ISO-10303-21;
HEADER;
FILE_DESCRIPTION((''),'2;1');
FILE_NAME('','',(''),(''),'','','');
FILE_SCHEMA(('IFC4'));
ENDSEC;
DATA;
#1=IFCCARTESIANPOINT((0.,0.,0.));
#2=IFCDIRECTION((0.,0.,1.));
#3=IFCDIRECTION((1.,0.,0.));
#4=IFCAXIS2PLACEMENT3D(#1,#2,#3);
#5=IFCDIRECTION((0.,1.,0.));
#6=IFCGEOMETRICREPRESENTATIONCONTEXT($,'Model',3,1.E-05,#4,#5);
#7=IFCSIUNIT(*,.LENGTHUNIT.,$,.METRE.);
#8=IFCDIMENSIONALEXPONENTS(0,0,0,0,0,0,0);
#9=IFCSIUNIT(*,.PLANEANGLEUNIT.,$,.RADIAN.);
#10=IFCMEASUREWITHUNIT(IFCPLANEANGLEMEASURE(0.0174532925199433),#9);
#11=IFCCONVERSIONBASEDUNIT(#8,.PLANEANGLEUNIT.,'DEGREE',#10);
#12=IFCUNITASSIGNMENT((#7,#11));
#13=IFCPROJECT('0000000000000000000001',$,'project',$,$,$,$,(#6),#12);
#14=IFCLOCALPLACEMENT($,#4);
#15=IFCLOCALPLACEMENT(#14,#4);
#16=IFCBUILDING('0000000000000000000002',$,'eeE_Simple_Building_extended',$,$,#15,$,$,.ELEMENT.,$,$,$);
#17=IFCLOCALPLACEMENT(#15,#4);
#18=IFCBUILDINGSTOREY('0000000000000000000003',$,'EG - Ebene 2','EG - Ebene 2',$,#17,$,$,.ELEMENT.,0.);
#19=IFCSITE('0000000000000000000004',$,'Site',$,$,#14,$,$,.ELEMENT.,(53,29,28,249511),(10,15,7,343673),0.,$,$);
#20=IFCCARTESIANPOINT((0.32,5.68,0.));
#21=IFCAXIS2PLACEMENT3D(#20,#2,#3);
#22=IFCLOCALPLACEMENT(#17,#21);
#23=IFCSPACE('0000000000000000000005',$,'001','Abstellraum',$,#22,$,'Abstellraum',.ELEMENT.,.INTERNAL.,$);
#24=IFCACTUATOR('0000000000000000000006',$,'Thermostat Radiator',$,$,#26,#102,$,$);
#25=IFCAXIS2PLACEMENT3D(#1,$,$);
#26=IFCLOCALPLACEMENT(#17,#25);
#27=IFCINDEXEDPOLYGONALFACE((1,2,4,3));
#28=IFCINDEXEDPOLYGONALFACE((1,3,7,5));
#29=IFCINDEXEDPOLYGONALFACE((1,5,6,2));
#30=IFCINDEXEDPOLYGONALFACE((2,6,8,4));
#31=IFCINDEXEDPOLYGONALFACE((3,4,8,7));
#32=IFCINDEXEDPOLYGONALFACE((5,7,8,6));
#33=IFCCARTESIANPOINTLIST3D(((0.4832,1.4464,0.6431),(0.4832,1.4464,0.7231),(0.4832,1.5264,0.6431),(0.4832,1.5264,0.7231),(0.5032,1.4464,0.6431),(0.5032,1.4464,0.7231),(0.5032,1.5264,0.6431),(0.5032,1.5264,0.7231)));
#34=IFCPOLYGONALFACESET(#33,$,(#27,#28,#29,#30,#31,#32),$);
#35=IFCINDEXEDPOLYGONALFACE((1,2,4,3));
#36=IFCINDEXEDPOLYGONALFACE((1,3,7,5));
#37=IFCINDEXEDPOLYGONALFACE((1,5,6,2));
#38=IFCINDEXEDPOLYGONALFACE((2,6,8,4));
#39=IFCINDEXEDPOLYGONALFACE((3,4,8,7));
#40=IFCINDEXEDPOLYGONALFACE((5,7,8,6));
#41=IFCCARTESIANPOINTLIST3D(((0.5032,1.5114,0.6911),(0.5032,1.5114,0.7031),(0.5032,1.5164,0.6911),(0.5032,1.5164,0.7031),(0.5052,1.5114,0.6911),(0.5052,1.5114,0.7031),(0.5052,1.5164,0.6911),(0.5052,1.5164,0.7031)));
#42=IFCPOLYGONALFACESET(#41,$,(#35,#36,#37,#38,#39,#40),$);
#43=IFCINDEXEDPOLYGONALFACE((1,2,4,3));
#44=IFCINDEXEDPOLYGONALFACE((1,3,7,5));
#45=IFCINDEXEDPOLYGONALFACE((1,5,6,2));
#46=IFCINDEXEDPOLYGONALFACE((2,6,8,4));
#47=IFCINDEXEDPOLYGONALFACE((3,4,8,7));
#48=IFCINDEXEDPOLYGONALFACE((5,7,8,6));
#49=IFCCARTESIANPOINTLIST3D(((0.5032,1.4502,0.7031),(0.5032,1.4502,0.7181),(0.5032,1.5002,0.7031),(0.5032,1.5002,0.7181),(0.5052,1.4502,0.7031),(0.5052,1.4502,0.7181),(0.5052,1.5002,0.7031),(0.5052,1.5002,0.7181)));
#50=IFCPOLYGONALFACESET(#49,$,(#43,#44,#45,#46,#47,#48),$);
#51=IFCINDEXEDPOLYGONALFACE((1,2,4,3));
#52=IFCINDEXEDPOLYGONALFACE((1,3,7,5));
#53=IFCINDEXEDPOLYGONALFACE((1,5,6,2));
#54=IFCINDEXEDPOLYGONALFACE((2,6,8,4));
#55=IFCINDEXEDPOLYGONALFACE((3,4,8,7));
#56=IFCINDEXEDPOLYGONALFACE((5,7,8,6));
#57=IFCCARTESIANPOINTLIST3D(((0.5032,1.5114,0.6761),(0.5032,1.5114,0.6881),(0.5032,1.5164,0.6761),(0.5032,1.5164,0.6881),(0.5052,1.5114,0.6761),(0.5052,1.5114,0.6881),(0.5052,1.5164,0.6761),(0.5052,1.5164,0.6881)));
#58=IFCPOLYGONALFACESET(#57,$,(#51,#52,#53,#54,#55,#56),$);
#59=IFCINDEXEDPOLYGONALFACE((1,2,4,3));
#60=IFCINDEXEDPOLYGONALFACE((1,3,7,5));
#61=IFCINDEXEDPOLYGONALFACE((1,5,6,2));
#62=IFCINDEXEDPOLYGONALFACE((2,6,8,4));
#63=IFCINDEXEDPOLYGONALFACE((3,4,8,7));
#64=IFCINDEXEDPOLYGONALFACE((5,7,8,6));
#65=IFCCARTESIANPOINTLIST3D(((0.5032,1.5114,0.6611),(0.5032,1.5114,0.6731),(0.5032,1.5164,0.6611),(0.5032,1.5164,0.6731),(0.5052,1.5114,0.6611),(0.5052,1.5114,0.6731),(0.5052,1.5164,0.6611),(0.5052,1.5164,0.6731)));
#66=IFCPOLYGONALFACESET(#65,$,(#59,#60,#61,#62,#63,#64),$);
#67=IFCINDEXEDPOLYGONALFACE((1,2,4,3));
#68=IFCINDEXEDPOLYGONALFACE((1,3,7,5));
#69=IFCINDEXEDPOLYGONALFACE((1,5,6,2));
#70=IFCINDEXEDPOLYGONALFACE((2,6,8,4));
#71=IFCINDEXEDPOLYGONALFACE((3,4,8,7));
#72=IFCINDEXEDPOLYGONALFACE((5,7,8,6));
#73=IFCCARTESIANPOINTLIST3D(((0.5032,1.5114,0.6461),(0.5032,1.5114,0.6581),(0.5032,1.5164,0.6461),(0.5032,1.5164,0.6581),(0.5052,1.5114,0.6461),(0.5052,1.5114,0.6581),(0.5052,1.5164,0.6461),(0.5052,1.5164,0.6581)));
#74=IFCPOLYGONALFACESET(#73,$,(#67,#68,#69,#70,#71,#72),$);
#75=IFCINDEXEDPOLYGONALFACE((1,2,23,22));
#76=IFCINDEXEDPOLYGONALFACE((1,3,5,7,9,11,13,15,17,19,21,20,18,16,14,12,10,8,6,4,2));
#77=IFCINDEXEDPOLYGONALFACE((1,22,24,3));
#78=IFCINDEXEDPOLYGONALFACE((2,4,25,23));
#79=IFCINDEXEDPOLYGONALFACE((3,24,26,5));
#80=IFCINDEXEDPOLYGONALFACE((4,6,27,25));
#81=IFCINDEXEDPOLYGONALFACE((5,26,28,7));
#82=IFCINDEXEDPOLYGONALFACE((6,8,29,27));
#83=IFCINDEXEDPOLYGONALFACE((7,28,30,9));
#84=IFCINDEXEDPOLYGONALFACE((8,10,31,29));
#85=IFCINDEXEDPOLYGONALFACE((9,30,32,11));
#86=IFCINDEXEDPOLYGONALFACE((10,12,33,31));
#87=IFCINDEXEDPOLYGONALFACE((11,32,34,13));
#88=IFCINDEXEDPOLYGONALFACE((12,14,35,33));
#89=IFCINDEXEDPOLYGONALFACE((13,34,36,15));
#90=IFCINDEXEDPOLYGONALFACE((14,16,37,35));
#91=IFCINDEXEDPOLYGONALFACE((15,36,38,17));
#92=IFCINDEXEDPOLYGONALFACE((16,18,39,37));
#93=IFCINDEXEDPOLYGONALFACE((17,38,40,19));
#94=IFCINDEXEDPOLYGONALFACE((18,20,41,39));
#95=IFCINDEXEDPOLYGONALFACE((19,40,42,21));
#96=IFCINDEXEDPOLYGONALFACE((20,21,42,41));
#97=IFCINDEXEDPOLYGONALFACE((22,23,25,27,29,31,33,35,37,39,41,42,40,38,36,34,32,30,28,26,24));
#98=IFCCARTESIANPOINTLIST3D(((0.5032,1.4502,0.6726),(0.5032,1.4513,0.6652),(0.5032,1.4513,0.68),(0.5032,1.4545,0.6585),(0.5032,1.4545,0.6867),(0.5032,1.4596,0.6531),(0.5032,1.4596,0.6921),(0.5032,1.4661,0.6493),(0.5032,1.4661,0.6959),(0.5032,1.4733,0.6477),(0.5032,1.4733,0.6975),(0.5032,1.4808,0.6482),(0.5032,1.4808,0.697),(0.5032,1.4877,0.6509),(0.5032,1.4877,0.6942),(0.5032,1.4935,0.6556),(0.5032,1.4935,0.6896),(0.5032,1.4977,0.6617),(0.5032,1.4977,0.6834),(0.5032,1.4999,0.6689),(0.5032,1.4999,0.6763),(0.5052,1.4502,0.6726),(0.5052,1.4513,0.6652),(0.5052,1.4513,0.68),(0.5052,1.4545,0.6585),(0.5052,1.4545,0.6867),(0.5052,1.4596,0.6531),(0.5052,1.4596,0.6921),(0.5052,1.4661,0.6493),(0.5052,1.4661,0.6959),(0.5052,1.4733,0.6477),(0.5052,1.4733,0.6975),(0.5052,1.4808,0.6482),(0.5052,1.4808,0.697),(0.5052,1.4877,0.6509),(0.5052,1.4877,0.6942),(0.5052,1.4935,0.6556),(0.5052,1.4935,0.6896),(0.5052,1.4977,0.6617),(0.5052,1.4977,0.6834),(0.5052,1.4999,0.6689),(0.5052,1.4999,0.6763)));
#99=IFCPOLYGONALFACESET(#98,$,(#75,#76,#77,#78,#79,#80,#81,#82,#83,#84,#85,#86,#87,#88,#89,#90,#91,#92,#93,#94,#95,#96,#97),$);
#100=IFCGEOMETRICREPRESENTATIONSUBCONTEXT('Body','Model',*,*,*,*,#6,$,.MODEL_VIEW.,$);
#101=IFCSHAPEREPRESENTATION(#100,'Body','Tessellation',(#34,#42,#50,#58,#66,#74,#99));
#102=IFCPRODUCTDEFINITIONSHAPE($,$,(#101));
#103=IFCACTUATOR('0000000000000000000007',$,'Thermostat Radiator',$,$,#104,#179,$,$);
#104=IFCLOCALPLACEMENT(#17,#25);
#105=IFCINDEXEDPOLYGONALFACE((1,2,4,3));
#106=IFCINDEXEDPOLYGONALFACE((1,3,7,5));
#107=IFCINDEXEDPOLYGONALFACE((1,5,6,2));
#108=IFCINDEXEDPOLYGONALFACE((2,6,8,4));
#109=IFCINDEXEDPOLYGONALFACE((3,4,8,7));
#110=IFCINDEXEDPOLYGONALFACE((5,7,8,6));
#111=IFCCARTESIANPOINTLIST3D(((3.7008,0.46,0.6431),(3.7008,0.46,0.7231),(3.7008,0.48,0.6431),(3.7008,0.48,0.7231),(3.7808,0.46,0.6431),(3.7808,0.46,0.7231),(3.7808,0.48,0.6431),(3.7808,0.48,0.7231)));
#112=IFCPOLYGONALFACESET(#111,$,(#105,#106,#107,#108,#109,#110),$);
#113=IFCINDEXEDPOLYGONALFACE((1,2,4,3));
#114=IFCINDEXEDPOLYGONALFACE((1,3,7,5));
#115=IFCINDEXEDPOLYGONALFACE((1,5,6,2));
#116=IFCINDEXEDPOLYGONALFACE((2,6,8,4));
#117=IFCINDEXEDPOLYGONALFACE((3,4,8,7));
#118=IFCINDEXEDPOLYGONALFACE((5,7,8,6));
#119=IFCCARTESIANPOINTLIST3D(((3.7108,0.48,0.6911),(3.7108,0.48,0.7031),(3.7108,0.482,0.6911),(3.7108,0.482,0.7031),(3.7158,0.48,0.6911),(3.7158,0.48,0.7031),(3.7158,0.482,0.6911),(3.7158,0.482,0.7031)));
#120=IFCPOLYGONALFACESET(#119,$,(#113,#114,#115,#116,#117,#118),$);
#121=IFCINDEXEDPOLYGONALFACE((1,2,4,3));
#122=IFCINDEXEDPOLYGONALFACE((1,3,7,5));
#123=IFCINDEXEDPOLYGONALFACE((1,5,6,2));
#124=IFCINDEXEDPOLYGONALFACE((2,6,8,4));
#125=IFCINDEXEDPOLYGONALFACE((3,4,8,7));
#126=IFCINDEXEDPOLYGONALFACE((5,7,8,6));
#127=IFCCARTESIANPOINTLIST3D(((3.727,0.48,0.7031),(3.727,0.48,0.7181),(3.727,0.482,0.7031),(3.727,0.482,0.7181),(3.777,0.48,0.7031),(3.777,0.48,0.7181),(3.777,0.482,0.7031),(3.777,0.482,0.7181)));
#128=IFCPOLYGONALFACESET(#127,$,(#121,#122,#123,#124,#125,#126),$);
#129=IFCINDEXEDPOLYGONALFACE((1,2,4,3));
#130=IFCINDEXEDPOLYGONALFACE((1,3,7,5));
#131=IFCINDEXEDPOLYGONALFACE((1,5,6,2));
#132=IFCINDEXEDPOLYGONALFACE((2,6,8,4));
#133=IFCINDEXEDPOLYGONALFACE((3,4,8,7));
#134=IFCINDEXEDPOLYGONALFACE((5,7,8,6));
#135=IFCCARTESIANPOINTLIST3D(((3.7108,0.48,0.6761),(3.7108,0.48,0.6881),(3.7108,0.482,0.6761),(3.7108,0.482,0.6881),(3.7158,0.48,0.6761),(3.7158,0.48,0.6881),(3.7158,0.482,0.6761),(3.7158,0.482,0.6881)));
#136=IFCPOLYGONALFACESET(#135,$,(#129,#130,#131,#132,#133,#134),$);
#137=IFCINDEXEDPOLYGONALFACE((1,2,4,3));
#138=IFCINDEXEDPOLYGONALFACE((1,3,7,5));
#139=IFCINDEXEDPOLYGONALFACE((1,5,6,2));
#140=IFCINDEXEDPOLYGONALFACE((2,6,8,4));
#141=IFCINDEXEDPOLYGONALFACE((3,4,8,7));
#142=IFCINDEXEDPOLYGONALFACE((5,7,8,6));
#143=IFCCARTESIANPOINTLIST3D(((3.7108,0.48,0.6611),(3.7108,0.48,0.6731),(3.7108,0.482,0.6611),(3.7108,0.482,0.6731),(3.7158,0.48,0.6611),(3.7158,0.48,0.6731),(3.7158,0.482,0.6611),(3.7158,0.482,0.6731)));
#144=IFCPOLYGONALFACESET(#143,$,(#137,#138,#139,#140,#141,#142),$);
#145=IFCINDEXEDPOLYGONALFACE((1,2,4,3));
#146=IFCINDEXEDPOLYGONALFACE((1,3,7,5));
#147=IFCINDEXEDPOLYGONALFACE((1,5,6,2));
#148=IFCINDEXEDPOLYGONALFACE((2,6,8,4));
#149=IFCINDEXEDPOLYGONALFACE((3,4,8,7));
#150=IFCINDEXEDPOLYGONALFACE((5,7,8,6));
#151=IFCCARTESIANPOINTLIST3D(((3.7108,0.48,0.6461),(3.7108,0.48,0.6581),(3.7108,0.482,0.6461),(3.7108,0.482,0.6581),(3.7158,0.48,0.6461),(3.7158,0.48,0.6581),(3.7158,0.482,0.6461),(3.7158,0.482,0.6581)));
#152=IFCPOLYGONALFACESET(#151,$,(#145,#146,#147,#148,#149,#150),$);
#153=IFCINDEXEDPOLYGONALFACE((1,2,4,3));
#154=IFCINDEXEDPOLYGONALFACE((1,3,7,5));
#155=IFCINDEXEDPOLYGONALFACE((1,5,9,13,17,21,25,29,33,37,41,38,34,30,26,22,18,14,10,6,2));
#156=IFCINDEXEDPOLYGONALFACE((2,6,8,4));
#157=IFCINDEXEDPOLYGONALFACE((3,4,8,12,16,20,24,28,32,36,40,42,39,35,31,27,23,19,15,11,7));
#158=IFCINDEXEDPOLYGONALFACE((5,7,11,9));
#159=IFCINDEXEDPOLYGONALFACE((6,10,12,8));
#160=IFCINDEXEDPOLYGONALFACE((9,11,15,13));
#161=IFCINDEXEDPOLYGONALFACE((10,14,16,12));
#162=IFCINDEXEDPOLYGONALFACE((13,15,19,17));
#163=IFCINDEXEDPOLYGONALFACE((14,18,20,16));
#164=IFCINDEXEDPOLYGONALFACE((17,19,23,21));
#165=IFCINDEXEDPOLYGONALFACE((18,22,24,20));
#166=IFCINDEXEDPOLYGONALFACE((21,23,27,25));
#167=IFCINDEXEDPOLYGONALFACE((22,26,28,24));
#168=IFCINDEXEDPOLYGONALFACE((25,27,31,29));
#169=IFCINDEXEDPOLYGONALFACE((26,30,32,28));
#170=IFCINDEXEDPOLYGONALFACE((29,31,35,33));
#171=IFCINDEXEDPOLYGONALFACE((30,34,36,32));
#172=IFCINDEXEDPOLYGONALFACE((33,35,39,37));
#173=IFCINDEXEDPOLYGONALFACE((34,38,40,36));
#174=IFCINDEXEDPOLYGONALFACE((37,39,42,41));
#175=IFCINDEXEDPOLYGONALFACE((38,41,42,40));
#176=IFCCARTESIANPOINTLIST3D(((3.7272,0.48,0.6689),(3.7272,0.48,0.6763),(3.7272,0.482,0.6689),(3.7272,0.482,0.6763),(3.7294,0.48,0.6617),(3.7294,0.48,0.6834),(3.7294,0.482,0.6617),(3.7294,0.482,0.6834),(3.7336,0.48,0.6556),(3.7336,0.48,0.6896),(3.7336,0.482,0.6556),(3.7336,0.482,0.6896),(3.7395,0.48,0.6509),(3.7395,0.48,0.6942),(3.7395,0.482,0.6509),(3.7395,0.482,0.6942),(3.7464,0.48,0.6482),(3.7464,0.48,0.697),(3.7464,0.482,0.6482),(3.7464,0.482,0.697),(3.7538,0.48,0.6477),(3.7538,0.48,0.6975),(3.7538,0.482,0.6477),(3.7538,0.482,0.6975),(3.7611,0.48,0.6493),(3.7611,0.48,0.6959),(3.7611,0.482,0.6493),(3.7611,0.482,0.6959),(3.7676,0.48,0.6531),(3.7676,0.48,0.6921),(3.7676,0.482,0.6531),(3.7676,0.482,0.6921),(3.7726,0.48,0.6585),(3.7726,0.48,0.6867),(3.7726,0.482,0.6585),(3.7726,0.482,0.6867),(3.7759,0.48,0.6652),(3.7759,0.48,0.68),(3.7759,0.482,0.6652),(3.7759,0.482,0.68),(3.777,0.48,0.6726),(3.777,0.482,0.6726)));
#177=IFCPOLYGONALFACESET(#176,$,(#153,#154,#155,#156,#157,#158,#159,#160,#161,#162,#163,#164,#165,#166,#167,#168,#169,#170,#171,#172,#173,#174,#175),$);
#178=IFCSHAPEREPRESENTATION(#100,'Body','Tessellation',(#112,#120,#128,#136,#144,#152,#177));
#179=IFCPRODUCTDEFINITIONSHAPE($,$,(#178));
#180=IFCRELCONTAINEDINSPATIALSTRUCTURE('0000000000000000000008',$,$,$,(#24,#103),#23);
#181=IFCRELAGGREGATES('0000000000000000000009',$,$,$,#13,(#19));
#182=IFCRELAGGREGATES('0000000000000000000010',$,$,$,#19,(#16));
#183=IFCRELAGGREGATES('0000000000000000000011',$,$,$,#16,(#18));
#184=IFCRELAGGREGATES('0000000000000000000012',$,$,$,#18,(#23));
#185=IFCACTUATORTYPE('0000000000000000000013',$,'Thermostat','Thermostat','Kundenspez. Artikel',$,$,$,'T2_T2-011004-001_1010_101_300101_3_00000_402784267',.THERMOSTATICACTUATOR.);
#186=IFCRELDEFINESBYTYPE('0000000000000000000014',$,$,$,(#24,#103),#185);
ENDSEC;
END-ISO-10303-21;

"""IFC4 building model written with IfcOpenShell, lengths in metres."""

from ifc_helpers import new_model, entity, si_unit, converted_unit, direction, frame, origin_with_axes, origin_2d_with_axis, place, context, subcontext, project, spatial, rectangle, circle, extrude, source, transform, mapped, type_object, element, save


model = new_model("IFC4")

# Units and contexts
model_context = context("Model", 3, precision=1e-05, world=origin_with_axes(), true_north=direction((0.0, 1.0, 0.0)))
body_context = subcontext(model_context, "Body", "Model", "MODEL_VIEW")
ifc_project = project(units=[si_unit("LENGTHUNIT", "METRE"), converted_unit("PLANEANGLEUNIT", "DEGREE", entity("IfcPlaneAngleMeasure", 0.0174532925199433), si_unit("PLANEANGLEUNIT", "RADIAN"), dimensions=[0, 0, 0, 0, 0, 0, 0])], contexts=[model_context])

# Site, building, storey
site_placement = place(None, origin_with_axes())
site = spatial("IfcSite", under=ifc_project, at=site_placement, Name="Site", CompositionType="ELEMENT", RefLatitude=(53, 29, 28, 249511), RefLongitude=(10, 15, 7, 343673), RefElevation=0.0)
building_placement = place(site_placement, origin_with_axes())
building = spatial("IfcBuilding", under=site, at=building_placement, Name="eeE_Simple_Building_extended", CompositionType="ELEMENT")
storey_placement = place(building_placement, origin_with_axes())
storey = spatial("IfcBuildingStorey", under=building, at=storey_placement, Name="EG - Ebene 2", Description="EG - Ebene 2", CompositionType="ELEMENT", Elevation=0.0)

# Shared definitions
space_placement = place(storey_placement, frame((0.32, 5.68, 0.0), z_axis=(0.0, 0.0, 1.0), x_axis=(1.0, 0.0, 0.0)))
space = spatial("IfcSpace", under=storey, at=space_placement, Name="001", Description="Abstellraum", LongName="Abstellraum", CompositionType="ELEMENT", PredefinedType="INTERNAL")

# Actuators
actuator_type = type_object("IfcActuatorType", Name="Thermostat", Description="Thermostat", ApplicableOccurrence="Kundenspez. Artikel", ElementType="T2_T2-011004-001_1010_101_300101_3_00000_402784267", PredefinedType="THERMOSTATICACTUATOR")
shared_shape_1 = source(origin_with_axes(), body_context, "Body", "SweptSolid", [
    extrude(rectangle(XDim=0.08, YDim=0.08, at=origin_2d_with_axis()), frame((0.0, 0.0, 0.0), z_axis=(0.0, 1.0, 0.0), x_axis=(1.0, 0.0, 0.0)), (0.0, 0.0, 1.0), 0.02),
    extrude(rectangle(XDim=0.005, YDim=0.012, at=origin_2d_with_axis()), frame((-0.0275, 0.02, 0.014), z_axis=(0.0, 1.0, 0.0), x_axis=(1.0, 0.0, 0.0)), (0.0, 0.0, 1.0), 0.002),
    extrude(rectangle(XDim=0.05, YDim=0.015, at=origin_2d_with_axis()), frame((0.0112, 0.02, 0.0275), z_axis=(0.0, 1.0, 0.0), x_axis=(1.0, 0.0, 0.0)), (0.0, 0.0, 1.0), 0.002),
    extrude(rectangle(XDim=0.005, YDim=0.012, at=origin_2d_with_axis()), frame((-0.0275, 0.02, -0.001), z_axis=(0.0, 1.0, 0.0), x_axis=(1.0, 0.0, 0.0)), (0.0, 0.0, 1.0), 0.002),
    extrude(rectangle(XDim=0.005, YDim=0.012, at=origin_2d_with_axis()), frame((-0.0275, 0.02, -0.016), z_axis=(0.0, 1.0, 0.0), x_axis=(1.0, 0.0, 0.0)), (0.0, 0.0, 1.0), 0.002),
    extrude(rectangle(XDim=0.005, YDim=0.012, at=origin_2d_with_axis()), frame((-0.0275, 0.02, -0.031), z_axis=(0.0, 1.0, 0.0), x_axis=(1.0, 0.0, 0.0)), (0.0, 0.0, 1.0), 0.002),
    extrude(circle(Radius=0.025, at=origin_2d_with_axis()), frame((0.0112, 0.02, -0.0105), z_axis=(0.0, 1.0, 0.0), x_axis=(1.0, 0.0, 0.0)), (0.0, 0.0, 1.0), 0.002),
])
for number, where, z_axis, x_axis, name in (
    (1, (0.1632, -4.1936, 0.6831), (0.0, 0.0, 1.0), (0.0, -1.0, 0.0), "Thermostat Radiator"),
    (2, (3.4208, -5.22, 0.6831), (0.0, 0.0, 1.0), (1.0, 0.0, 0.0), "Thermostat Radiator"),
):
    element("IfcActuator", number, at=place(space_placement, frame(where, z_axis=z_axis, x_axis=x_axis)), inside=space, type_object=actuator_type, Name=name, context=body_context, shape_type="MappedRepresentation", body=[
        mapped(shared_shape_1, transform((0.0, 0.0, 0.0), x_axis=(1.0, 0.0, 0.0), y_axis=(0.0, 1.0, 0.0), z_axis=(0.0, 0.0, 1.0), scale=1.0)),
    ])

save(model, "model.ifc")
